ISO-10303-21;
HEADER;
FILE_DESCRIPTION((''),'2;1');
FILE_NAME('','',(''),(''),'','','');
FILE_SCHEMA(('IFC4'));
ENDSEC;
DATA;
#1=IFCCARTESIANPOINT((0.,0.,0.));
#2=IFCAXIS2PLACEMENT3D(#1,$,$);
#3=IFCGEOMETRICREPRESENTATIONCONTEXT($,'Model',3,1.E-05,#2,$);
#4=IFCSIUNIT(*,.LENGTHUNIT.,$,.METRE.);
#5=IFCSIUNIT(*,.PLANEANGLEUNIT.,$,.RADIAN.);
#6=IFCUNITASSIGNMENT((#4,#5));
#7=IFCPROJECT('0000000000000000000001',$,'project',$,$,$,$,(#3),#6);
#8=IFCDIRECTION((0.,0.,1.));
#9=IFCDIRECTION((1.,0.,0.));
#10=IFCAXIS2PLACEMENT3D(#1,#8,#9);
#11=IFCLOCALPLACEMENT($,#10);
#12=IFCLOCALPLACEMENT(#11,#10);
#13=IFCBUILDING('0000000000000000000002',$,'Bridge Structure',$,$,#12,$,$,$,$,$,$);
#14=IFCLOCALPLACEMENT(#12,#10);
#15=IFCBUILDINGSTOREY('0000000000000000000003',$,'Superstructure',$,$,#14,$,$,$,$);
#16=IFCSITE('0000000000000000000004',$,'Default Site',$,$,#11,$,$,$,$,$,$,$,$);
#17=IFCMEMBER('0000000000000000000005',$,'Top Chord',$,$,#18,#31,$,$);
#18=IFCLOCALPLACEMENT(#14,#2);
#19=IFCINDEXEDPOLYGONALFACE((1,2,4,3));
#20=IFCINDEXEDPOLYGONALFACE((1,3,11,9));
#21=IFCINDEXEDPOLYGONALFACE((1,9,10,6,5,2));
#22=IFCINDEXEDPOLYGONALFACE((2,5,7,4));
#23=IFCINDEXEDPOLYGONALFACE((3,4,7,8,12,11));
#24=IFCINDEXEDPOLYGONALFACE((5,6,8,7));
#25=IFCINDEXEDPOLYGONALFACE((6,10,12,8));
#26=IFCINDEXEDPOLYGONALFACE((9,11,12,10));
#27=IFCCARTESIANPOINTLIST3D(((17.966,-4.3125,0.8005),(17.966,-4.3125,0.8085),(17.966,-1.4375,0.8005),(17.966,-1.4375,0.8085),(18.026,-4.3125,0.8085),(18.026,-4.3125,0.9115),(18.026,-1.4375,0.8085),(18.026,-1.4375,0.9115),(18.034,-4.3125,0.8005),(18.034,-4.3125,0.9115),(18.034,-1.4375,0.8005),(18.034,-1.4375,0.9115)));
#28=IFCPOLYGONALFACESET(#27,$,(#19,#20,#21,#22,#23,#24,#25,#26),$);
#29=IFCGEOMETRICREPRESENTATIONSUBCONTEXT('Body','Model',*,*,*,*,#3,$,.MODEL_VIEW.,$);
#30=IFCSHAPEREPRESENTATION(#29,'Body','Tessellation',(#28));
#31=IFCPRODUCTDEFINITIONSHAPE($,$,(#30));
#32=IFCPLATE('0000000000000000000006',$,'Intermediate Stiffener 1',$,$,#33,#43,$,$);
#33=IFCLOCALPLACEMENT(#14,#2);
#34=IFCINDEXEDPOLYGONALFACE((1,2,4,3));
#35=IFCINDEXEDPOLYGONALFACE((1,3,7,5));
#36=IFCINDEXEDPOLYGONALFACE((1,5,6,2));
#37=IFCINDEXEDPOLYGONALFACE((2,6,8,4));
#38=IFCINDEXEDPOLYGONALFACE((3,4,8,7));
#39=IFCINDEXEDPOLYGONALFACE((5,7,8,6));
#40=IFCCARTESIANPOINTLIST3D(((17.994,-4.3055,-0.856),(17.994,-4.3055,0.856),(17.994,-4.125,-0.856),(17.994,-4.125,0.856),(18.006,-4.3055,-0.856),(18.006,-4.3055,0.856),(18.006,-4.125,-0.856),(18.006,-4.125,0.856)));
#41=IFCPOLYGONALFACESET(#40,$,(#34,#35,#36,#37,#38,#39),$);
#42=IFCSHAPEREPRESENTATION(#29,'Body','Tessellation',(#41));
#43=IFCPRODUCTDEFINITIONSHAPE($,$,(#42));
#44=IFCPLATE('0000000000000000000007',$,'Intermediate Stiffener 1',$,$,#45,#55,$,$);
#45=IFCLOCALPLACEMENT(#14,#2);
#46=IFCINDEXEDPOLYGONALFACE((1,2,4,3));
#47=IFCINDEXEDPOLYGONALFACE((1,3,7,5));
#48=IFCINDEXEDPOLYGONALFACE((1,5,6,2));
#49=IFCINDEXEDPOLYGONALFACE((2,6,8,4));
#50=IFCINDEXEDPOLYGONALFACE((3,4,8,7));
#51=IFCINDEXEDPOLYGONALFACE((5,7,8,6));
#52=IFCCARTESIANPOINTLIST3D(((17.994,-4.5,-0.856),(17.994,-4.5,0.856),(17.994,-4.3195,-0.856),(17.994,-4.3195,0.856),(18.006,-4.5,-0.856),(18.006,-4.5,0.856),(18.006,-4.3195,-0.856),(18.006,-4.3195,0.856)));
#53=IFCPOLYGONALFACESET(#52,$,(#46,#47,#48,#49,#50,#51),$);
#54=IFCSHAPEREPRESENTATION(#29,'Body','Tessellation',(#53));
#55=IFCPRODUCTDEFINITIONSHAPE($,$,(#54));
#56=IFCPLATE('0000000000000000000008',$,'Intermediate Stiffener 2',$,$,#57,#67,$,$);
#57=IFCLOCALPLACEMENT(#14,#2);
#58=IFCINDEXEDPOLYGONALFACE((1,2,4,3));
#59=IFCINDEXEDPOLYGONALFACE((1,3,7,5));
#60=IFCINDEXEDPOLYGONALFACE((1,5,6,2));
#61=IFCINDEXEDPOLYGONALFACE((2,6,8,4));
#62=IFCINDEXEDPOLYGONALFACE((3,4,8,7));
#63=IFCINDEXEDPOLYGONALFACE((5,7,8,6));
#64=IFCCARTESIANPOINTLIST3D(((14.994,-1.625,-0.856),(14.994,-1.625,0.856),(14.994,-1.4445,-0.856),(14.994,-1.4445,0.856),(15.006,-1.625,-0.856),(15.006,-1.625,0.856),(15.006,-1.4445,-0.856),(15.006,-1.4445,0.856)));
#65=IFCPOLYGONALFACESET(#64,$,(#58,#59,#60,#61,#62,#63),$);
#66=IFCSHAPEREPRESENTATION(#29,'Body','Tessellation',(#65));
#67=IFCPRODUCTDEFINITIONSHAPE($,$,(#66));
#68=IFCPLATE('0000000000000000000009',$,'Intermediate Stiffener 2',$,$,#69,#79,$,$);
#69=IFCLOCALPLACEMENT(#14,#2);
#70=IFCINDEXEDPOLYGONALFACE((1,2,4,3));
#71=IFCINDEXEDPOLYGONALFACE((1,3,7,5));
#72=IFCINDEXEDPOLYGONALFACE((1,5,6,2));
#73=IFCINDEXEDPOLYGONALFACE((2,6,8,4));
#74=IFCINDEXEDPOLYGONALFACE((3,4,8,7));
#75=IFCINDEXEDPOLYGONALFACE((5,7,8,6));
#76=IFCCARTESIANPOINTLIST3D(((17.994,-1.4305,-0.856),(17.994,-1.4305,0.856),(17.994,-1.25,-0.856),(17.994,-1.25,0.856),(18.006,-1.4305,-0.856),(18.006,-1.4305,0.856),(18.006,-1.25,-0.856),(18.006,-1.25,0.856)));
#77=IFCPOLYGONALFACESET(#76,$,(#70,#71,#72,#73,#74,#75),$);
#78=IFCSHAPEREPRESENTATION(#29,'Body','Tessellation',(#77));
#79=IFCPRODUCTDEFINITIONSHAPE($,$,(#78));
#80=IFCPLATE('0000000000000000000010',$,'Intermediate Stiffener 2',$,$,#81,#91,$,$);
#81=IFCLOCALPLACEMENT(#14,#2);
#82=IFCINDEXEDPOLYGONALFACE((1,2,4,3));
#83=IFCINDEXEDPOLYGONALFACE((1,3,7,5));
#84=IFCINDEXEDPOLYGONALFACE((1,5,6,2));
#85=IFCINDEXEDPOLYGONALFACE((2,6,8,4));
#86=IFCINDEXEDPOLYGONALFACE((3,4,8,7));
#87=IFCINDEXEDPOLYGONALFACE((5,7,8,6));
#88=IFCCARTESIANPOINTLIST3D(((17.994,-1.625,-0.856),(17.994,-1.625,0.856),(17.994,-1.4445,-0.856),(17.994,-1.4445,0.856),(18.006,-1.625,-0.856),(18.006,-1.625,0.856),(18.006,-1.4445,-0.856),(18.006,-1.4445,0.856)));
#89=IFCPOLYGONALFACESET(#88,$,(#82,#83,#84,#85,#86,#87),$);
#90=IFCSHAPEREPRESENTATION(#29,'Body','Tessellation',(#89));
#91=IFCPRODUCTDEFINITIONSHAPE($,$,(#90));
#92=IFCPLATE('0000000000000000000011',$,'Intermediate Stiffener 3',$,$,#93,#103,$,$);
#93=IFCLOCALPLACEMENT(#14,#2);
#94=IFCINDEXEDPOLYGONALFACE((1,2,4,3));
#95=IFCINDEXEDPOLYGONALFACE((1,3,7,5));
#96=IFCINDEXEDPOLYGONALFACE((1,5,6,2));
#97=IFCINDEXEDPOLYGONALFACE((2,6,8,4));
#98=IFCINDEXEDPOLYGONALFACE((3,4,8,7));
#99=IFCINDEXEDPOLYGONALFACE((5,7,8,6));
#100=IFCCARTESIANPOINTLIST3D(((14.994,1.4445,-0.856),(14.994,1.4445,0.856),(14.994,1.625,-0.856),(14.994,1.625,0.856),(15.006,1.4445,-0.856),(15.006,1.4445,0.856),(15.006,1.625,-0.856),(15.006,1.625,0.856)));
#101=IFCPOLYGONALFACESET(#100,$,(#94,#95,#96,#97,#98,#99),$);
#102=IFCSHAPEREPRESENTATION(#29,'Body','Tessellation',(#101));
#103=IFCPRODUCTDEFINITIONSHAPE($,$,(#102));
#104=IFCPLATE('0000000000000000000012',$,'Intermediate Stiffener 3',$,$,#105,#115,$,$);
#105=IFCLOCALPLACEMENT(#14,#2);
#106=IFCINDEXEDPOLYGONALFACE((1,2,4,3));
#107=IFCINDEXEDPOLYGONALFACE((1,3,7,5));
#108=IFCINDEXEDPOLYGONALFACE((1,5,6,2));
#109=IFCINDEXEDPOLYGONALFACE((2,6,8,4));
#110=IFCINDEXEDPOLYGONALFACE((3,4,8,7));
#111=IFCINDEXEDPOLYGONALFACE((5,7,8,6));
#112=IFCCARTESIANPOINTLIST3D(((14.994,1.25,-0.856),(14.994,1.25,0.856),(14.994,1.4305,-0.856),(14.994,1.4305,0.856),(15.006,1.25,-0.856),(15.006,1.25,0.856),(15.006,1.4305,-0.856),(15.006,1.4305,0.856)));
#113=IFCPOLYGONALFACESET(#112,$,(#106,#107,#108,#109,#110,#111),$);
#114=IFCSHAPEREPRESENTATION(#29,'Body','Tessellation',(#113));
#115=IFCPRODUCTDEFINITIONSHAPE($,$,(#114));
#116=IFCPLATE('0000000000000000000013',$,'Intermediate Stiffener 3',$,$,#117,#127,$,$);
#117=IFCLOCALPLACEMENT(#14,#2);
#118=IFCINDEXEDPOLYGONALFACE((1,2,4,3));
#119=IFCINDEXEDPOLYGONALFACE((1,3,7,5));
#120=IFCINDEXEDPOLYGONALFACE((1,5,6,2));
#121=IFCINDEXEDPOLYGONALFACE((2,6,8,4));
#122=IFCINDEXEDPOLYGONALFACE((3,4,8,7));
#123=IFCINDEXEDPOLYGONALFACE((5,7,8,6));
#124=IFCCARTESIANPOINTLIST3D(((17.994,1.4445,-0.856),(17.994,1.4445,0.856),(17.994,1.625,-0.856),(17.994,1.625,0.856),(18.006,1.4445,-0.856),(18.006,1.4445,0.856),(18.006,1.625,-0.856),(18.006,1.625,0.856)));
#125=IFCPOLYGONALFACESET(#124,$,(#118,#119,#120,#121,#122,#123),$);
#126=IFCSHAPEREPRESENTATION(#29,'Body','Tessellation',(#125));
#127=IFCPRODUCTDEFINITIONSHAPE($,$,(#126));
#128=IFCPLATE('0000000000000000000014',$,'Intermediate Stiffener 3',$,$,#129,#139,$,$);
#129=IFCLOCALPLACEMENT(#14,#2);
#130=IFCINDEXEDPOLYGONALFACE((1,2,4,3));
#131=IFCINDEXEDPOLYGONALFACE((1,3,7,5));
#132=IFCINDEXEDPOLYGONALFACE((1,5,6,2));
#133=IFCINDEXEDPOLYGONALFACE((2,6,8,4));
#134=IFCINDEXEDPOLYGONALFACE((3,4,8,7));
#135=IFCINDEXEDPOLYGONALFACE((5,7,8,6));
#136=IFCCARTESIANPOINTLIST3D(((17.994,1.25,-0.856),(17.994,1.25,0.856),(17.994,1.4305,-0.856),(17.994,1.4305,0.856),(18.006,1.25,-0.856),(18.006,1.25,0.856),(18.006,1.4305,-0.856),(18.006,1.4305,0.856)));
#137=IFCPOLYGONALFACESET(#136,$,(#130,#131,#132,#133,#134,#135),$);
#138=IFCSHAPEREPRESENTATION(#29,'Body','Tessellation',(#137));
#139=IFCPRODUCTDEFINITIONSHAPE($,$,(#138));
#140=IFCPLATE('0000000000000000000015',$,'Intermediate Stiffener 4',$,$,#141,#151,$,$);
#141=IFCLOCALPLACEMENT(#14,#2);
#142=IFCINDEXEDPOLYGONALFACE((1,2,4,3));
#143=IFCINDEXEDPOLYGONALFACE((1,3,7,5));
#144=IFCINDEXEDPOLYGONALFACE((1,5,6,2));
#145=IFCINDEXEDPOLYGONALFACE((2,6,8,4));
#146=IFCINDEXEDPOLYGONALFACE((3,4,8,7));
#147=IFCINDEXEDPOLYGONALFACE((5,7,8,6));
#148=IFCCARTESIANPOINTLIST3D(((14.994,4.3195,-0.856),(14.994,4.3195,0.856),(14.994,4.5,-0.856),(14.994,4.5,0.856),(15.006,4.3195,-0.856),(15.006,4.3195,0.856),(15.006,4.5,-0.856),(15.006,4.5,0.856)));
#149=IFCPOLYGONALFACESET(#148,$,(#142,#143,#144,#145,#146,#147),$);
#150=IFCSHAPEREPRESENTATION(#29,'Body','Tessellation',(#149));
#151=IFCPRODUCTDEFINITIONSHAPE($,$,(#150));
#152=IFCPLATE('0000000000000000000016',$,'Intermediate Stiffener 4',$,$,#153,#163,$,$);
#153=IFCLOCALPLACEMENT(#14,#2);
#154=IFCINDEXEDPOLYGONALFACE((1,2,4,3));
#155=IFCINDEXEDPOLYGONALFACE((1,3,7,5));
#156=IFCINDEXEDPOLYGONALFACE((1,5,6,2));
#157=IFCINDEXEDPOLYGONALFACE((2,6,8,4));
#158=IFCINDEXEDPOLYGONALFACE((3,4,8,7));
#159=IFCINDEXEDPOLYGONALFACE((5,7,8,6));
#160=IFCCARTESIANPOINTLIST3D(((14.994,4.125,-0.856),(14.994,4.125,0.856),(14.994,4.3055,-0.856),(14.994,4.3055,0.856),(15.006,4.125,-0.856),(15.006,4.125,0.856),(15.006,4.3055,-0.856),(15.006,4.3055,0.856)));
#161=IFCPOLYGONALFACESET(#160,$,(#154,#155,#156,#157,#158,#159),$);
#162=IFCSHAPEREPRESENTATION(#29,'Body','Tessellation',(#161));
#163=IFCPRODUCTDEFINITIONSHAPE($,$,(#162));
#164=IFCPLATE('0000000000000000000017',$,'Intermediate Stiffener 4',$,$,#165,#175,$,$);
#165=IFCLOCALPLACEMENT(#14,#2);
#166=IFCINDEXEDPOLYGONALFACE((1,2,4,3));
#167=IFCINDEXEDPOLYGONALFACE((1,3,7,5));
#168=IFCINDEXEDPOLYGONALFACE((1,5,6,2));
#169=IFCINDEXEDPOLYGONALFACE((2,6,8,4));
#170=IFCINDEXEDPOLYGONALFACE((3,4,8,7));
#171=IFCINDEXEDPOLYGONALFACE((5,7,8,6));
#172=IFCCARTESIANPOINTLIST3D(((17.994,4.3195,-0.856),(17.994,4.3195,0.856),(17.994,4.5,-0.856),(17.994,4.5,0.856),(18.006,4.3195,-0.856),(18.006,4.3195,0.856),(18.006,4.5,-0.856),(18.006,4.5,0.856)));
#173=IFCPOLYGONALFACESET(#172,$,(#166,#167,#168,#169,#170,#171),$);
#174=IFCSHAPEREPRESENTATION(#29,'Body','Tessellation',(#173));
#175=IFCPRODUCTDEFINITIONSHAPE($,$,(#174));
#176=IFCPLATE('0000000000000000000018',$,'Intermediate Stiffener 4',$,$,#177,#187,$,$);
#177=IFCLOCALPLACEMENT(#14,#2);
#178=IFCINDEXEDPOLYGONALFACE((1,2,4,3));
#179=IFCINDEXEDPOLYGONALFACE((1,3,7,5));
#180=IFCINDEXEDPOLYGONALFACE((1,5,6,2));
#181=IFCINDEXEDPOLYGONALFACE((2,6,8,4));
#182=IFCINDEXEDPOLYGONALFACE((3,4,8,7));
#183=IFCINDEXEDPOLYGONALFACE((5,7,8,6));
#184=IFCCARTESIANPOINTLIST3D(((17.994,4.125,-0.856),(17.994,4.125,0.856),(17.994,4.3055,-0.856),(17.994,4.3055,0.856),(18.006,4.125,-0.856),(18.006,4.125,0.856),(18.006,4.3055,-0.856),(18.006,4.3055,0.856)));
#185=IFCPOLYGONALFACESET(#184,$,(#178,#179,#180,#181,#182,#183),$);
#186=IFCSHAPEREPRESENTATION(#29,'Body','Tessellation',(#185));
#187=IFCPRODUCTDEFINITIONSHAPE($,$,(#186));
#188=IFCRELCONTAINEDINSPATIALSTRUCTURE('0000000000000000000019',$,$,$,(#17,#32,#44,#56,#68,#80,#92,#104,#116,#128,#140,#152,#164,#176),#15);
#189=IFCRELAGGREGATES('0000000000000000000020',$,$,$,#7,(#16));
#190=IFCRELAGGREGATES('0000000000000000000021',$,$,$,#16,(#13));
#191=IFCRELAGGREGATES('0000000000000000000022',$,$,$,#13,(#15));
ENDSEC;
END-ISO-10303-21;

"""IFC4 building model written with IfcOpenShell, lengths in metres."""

from ifc_helpers import new_model, si_unit, frame, origin, origin_with_axes, origin_2d_with_axis, place, context, subcontext, project, spatial, rectangle, l_section, extrude, element, save


model = new_model("IFC4")

# Units and contexts
model_context = context("Model", 3, precision=1e-05, world=origin())
body_context = subcontext(model_context, "Body", "Model", "MODEL_VIEW")
ifc_project = project(units=[si_unit("LENGTHUNIT", "METRE"), si_unit("PLANEANGLEUNIT", "RADIAN")], contexts=[model_context])

# Site, building, storey
site_placement = place(None, origin_with_axes())
site = spatial("IfcSite", under=ifc_project, at=site_placement, Name="Default Site")
building_placement = place(site_placement, origin_with_axes())
building = spatial("IfcBuilding", under=site, at=building_placement, Name="Bridge Structure")
storey_placement = place(building_placement, origin_with_axes())
storey = spatial("IfcBuildingStorey", under=building, at=storey_placement, Name="Superstructure")

# Member
for number, where, z_axis, x_axis, name in (
    (1, (18.0, -4.3125, 0.856), (0.0, 1.0, 0.0), (-1.0, 0.0, 0.0), "Top Chord"),
):
    element("IfcMember", number, at=place(storey_placement, frame(where, z_axis=z_axis, x_axis=x_axis)), inside=storey, Name=name, context=body_context, shape_type="SweptSolid", body=[
        extrude(l_section(Depth=0.111, Width=0.068, Thickness=0.008, at=origin_2d_with_axis()), origin_with_axes(), (0.0, 0.0, 1.0), 2.875),
    ])

# Plates
for number, where, z_axis, x_axis, name in (
    (2, (18.0, -4.2153, -0.856), (0.0, 0.0, 1.0), (1.0, 0.0, 0.0), "Intermediate Stiffener 1"),
    (3, (18.0, -4.4097, -0.856), (0.0, 0.0, 1.0), (1.0, 0.0, 0.0), "Intermediate Stiffener 1"),
    (4, (15.0, -1.5348, -0.856), (0.0, 0.0, 1.0), (1.0, 0.0, 0.0), "Intermediate Stiffener 2"),
    (5, (18.0, -1.3402, -0.856), (0.0, 0.0, 1.0), (1.0, 0.0, 0.0), "Intermediate Stiffener 2"),
    (6, (18.0, -1.5348, -0.856), (0.0, 0.0, 1.0), (1.0, 0.0, 0.0), "Intermediate Stiffener 2"),
    (7, (15.0, 1.5348, -0.856), (0.0, 0.0, 1.0), (1.0, 0.0, 0.0), "Intermediate Stiffener 3"),
    (8, (15.0, 1.3402, -0.856), (0.0, 0.0, 1.0), (1.0, 0.0, 0.0), "Intermediate Stiffener 3"),
    (9, (18.0, 1.5348, -0.856), (0.0, 0.0, 1.0), (1.0, 0.0, 0.0), "Intermediate Stiffener 3"),
    (10, (18.0, 1.3402, -0.856), (0.0, 0.0, 1.0), (1.0, 0.0, 0.0), "Intermediate Stiffener 3"),
    (11, (15.0, 4.4097, -0.856), (0.0, 0.0, 1.0), (1.0, 0.0, 0.0), "Intermediate Stiffener 4"),
    (12, (15.0, 4.2153, -0.856), (0.0, 0.0, 1.0), (1.0, 0.0, 0.0), "Intermediate Stiffener 4"),
    (13, (18.0, 4.4097, -0.856), (0.0, 0.0, 1.0), (1.0, 0.0, 0.0), "Intermediate Stiffener 4"),
    (14, (18.0, 4.2153, -0.856), (0.0, 0.0, 1.0), (1.0, 0.0, 0.0), "Intermediate Stiffener 4"),
):
    element("IfcPlate", number, at=place(storey_placement, frame(where, z_axis=z_axis, x_axis=x_axis)), inside=storey, Name=name, context=body_context, shape_type="SweptSolid", body=[
        extrude(rectangle(XDim=0.012, YDim=0.1805, at=origin_2d_with_axis()), origin_with_axes(), (0.0, 0.0, 1.0), 1.712),
    ])

save(model, "model.ifc")
